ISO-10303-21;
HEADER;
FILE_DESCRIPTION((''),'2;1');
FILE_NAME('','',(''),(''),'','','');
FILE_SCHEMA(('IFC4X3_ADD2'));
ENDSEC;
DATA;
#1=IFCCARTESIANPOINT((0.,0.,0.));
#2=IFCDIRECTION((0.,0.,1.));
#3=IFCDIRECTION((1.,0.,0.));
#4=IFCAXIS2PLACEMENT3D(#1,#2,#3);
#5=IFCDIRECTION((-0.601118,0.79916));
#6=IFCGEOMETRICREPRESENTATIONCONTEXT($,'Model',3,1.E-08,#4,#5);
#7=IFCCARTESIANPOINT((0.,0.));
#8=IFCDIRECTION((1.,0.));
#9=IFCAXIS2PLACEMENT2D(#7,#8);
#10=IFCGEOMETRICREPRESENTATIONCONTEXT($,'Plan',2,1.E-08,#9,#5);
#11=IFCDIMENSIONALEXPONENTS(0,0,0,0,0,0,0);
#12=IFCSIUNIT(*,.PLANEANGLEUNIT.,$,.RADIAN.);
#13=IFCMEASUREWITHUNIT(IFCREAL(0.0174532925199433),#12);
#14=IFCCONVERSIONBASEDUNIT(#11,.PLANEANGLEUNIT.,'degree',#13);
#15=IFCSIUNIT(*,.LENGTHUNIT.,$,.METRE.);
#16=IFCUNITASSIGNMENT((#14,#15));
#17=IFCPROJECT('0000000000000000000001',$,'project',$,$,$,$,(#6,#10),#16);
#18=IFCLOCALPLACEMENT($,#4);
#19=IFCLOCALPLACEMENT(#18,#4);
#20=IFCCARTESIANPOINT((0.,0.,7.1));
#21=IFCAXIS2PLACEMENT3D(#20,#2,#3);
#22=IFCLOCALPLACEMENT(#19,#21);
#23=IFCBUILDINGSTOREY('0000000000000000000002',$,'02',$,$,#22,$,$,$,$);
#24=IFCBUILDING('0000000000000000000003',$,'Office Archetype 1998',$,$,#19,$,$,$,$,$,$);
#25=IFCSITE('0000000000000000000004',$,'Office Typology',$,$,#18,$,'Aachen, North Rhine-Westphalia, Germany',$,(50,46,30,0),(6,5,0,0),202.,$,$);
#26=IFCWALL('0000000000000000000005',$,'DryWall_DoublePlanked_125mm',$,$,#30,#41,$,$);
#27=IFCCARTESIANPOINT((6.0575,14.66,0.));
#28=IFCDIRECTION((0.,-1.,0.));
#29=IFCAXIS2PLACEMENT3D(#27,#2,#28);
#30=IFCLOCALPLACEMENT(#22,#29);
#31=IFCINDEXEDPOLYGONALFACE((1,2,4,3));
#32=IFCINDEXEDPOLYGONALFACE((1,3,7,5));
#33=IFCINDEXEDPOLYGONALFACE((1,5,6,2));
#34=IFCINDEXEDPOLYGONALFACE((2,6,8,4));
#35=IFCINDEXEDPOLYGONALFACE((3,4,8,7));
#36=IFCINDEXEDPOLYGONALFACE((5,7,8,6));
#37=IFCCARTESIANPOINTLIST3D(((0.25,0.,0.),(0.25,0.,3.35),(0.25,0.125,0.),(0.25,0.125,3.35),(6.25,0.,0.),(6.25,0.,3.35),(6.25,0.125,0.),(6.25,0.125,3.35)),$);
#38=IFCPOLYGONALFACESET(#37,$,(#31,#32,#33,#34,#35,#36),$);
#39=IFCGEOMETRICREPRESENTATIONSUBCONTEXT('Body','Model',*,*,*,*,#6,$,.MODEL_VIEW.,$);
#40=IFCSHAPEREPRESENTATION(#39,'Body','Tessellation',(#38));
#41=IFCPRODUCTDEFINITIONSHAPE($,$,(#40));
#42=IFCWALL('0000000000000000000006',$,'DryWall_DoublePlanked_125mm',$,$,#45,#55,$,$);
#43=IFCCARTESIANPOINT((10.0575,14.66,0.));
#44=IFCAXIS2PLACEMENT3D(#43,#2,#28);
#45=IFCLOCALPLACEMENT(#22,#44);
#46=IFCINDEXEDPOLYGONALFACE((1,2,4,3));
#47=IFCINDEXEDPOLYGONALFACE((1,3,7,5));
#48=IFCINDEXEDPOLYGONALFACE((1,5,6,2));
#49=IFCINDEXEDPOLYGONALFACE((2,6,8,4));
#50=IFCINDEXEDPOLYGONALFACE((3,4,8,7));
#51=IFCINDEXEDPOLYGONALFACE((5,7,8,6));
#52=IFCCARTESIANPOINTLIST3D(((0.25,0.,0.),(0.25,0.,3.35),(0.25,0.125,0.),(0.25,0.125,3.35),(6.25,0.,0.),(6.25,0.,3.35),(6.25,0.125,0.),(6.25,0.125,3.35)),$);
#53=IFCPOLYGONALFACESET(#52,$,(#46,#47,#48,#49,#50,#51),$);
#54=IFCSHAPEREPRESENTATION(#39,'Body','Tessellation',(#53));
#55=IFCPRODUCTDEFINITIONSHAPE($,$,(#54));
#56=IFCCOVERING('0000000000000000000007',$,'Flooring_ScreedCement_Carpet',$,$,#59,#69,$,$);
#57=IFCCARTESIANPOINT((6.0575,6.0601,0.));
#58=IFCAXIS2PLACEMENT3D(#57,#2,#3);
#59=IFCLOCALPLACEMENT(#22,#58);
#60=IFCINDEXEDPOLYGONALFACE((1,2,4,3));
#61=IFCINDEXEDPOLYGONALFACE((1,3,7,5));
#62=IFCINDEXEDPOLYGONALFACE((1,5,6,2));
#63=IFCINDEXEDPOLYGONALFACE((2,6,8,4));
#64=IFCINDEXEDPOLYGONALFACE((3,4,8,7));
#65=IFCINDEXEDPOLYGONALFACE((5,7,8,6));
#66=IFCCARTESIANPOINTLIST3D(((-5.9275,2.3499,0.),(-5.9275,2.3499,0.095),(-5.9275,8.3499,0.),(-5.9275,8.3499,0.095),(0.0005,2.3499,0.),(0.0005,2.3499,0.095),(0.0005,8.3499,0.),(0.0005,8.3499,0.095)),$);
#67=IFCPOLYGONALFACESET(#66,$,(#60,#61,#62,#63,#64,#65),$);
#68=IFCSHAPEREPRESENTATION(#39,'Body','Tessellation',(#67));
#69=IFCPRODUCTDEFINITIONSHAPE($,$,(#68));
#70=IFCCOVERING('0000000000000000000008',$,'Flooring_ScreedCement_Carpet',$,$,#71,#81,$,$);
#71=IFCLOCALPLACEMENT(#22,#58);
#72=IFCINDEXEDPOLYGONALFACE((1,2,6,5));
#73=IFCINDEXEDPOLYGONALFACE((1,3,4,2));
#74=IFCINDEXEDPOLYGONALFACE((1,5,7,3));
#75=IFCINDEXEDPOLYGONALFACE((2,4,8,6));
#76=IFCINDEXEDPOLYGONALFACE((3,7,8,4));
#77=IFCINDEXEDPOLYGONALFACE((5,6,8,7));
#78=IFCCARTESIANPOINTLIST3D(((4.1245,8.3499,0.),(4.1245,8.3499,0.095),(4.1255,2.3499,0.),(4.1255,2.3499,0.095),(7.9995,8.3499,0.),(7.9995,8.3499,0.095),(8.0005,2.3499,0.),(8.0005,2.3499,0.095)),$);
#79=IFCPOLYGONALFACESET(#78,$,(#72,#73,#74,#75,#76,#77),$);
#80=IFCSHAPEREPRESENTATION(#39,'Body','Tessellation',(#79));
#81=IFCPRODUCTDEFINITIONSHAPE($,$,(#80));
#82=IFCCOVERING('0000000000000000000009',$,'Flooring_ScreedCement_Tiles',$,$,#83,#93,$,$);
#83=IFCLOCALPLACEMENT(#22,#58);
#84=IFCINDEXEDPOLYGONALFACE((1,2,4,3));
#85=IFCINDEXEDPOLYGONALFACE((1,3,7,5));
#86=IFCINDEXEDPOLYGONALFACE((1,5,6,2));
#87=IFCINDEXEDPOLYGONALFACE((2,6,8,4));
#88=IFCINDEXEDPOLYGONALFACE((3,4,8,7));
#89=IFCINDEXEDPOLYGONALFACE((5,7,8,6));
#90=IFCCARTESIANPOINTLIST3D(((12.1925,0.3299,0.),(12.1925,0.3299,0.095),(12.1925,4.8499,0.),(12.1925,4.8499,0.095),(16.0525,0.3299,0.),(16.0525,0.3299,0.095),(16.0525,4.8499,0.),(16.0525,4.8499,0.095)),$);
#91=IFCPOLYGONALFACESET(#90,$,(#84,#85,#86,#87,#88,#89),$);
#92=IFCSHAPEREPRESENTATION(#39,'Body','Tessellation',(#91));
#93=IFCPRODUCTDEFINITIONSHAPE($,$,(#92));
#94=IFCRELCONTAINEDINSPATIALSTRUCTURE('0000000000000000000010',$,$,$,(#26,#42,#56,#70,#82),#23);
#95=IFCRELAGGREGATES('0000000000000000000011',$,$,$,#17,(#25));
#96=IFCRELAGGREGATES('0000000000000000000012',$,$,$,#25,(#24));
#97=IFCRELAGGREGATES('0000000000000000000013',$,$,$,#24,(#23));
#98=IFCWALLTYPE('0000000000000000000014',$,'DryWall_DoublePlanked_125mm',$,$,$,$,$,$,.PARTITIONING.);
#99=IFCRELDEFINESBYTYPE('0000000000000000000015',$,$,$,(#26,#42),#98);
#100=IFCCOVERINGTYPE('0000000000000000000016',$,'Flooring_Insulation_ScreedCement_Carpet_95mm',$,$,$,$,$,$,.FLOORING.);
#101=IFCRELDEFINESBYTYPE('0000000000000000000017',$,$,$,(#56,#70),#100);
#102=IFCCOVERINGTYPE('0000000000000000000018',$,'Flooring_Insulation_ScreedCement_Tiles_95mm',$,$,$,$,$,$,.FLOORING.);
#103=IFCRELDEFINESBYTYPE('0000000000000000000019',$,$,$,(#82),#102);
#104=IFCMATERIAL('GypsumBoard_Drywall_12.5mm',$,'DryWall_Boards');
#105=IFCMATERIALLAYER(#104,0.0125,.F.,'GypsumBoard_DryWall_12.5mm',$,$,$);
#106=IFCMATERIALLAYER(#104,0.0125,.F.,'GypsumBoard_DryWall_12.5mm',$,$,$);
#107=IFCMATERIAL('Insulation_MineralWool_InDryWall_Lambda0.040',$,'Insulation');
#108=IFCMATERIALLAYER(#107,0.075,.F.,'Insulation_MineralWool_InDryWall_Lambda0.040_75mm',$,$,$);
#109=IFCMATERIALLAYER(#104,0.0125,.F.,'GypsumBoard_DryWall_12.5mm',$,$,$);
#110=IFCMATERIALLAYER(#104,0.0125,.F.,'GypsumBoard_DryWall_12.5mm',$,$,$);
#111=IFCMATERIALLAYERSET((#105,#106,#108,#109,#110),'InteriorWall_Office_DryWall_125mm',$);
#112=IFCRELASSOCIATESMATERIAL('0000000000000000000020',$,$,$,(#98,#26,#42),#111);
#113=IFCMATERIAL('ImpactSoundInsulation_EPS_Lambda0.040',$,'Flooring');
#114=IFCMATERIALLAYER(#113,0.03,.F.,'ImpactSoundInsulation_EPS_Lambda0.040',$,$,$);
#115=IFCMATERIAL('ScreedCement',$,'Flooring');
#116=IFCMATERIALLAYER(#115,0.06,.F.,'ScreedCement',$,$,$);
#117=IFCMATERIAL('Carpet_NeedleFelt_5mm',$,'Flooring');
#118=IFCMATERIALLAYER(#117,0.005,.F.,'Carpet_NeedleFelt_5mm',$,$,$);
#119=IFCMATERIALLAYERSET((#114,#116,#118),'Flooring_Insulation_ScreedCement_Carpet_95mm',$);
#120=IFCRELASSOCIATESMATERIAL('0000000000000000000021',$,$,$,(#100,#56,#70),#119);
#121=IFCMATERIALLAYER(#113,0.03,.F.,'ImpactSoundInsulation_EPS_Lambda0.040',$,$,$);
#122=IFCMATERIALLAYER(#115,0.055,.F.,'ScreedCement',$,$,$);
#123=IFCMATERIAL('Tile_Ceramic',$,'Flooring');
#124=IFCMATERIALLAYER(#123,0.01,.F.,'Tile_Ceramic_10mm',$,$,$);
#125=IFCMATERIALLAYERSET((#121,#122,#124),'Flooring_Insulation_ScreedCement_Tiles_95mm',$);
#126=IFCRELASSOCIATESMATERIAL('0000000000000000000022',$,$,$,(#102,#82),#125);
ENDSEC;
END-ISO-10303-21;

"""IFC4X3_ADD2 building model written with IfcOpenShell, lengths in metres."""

from ifc_helpers import new_model, entity, si_unit, converted_unit, direction, frame, origin_with_axes, origin_2d_with_axis, place, context, subcontext, project, spatial, line, indexed_curve, outline, extrude, material, layer, layer_set, layer_usage, type_object, element, save


model = new_model("IFC4X3_ADD2")

# Units and contexts
model_context = context("Model", 3, precision=1e-08, world=origin_with_axes(), true_north=direction((-0.601118, 0.79916)))
plan_context = context("Plan", 2, precision=1e-08, world=origin_2d_with_axis(), true_north=direction((-0.601118, 0.79916)))
body_context = subcontext(model_context, "Body", "Model", "MODEL_VIEW")
ifc_project = project(units=[converted_unit("PLANEANGLEUNIT", "degree", entity("IfcReal", 0.0174532925199433), si_unit("PLANEANGLEUNIT", "RADIAN"), dimensions=[0, 0, 0, 0, 0, 0, 0]), si_unit("LENGTHUNIT", "METRE")], contexts=[model_context, plan_context])

# Site, building, storey
site_placement = place(None, origin_with_axes())
site = spatial("IfcSite", under=ifc_project, at=site_placement, Name="Office Typology", LongName="Aachen, North Rhine-Westphalia, Germany", RefLatitude=(50, 46, 30, 0), RefLongitude=(6, 5, 0, 0), RefElevation=202.0)
building_placement = place(site_placement, origin_with_axes())
building = spatial("IfcBuilding", under=site, at=building_placement, Name="Office Archetype 1998")
storey_placement = place(building_placement, frame((0.0, 0.0, 7.1), z_axis=(0.0, 0.0, 1.0), x_axis=(1.0, 0.0, 0.0)))
storey = spatial("IfcBuildingStorey", under=building, at=storey_placement, Name="02")

# Walls
ifc_material_1 = material(Name="GypsumBoard_Drywall_12.5mm", Category="DryWall_Boards")
ifc_layer_1 = layer(ifc_material_1, 0.0125, ventilated=False, Name="GypsumBoard_DryWall_12.5mm")
ifc_layer_2 = layer(ifc_material_1, 0.0125, ventilated=False, Name="GypsumBoard_DryWall_12.5mm")
ifc_material_2 = material(Name="Insulation_MineralWool_InDryWall_Lambda0.040", Category="Insulation")
ifc_layer_3 = layer(ifc_material_2, 0.075, ventilated=False, Name="Insulation_MineralWool_InDryWall_Lambda0.040_75mm")
ifc_layer_4 = layer(ifc_material_1, 0.0125, ventilated=False, Name="GypsumBoard_DryWall_12.5mm")
ifc_layer_5 = layer(ifc_material_1, 0.0125, ventilated=False, Name="GypsumBoard_DryWall_12.5mm")
ifc_layer_set_1 = layer_set([ifc_layer_1, ifc_layer_2, ifc_layer_3, ifc_layer_4, ifc_layer_5], Name="InteriorWall_Office_DryWall_125mm")
wall_type_1 = type_object("IfcWallType", Name="DryWall_DoublePlanked_125mm", PredefinedType="PARTITIONING", material=ifc_layer_set_1)
ifc_layer_usage_1 = layer_usage(ifc_layer_set_1, "AXIS2", "POSITIVE", 0.0)
wall_1_placement = place(storey_placement, frame((6.0575, 14.66, 0.0), z_axis=(0.0, 0.0, 1.0), x_axis=(0.0, -1.0, 0.0)))
element("IfcWall", 1, at=wall_1_placement, inside=storey, type_object=wall_type_1, material=ifc_layer_usage_1, Name="DryWall_DoublePlanked_125mm", context=body_context, shape_type="SweptSolid", body=[
    extrude(outline(indexed_curve([(0.25, 0.0), (0.25, 0.125), (6.25, 0.125), (6.25, 0.0)], segments=[line(1, 2, 3, 4, 1)])), origin_with_axes(), (0.0, 0.0, 1.0), 3.35),
])
ifc_layer_usage_2 = layer_usage(ifc_layer_set_1, "AXIS2", "POSITIVE", 0.0)
wall_2_placement = place(storey_placement, frame((10.0575, 14.66, 0.0), z_axis=(0.0, 0.0, 1.0), x_axis=(0.0, -1.0, 0.0)))
element("IfcWall", 2, at=wall_2_placement, inside=storey, type_object=wall_type_1, material=ifc_layer_usage_2, Name="DryWall_DoublePlanked_125mm", context=body_context, shape_type="SweptSolid", body=[
    extrude(outline(indexed_curve([(0.25, 0.0), (0.25, 0.125), (6.25, 0.125), (6.25, 0.0)], segments=[line(1, 2, 3, 4, 1)])), origin_with_axes(), (0.0, 0.0, 1.0), 3.35),
])

# Coverings
ifc_material_3 = material(Name="ImpactSoundInsulation_EPS_Lambda0.040", Category="Flooring")
ifc_layer_6 = layer(ifc_material_3, 0.03, ventilated=False, Name="ImpactSoundInsulation_EPS_Lambda0.040")
ifc_material_4 = material(Name="ScreedCement", Category="Flooring")
ifc_layer_7 = layer(ifc_material_4, 0.06, ventilated=False, Name="ScreedCement")
ifc_material_5 = material(Name="Carpet_NeedleFelt_5mm", Category="Flooring")
ifc_layer_8 = layer(ifc_material_5, 0.005, ventilated=False, Name="Carpet_NeedleFelt_5mm")
ifc_layer_set_2 = layer_set([ifc_layer_6, ifc_layer_7, ifc_layer_8], Name="Flooring_Insulation_ScreedCement_Carpet_95mm")
ifc_layer_usage_3 = layer_usage(ifc_layer_set_2, "AXIS3", "POSITIVE", 0.0)
covering_type_1 = type_object("IfcCoveringType", Name="Flooring_Insulation_ScreedCement_Carpet_95mm", PredefinedType="FLOORING", material=ifc_layer_set_2)
covering_1_placement = place(storey_placement, frame((6.0575, 6.0601, 0.0), z_axis=(0.0, 0.0, 1.0), x_axis=(1.0, 0.0, 0.0)))
element("IfcCovering", 3, at=covering_1_placement, inside=storey, type_object=covering_type_1, material=ifc_layer_usage_3, Name="Flooring_ScreedCement_Carpet", context=body_context, shape_type="SweptSolid", body=[
    extrude(outline(indexed_curve([(-5.9275, 2.3499), (-5.9275, 8.3499), (0.0005, 8.3499), (0.0005, 2.3499)], segments=[line(1, 2, 3, 4, 1)])), origin_with_axes(), (0.0, 0.0, 1.0), 0.095),
])
ifc_layer_usage_4 = layer_usage(ifc_layer_set_2, "AXIS3", "POSITIVE", 0.0)
covering_2_placement = place(storey_placement, frame((6.0575, 6.0601, 0.0), z_axis=(0.0, 0.0, 1.0), x_axis=(1.0, 0.0, 0.0)))
element("IfcCovering", 4, at=covering_2_placement, inside=storey, type_object=covering_type_1, material=ifc_layer_usage_4, Name="Flooring_ScreedCement_Carpet", context=body_context, shape_type="SweptSolid", body=[
    extrude(outline(indexed_curve([(4.1255, 2.3499), (4.1245, 8.3499), (7.9995, 8.3499), (8.0005, 2.3499)], segments=[line(1, 2, 3, 4, 1)])), origin_with_axes(), (0.0, 0.0, 1.0), 0.095),
])
ifc_layer_9 = layer(ifc_material_3, 0.03, ventilated=False, Name="ImpactSoundInsulation_EPS_Lambda0.040")
ifc_layer_10 = layer(ifc_material_4, 0.055, ventilated=False, Name="ScreedCement")
ifc_material_6 = material(Name="Tile_Ceramic", Category="Flooring")
ifc_layer_11 = layer(ifc_material_6, 0.01, ventilated=False, Name="Tile_Ceramic_10mm")
ifc_layer_set_3 = layer_set([ifc_layer_9, ifc_layer_10, ifc_layer_11], Name="Flooring_Insulation_ScreedCement_Tiles_95mm")
ifc_layer_usage_5 = layer_usage(ifc_layer_set_3, "AXIS3", "POSITIVE", 0.0)
covering_type_2 = type_object("IfcCoveringType", Name="Flooring_Insulation_ScreedCement_Tiles_95mm", PredefinedType="FLOORING", material=ifc_layer_set_3)
covering_3_placement = place(storey_placement, frame((6.0575, 6.0601, 0.0), z_axis=(0.0, 0.0, 1.0), x_axis=(1.0, 0.0, 0.0)))
element("IfcCovering", 5, at=covering_3_placement, inside=storey, type_object=covering_type_2, material=ifc_layer_usage_5, Name="Flooring_ScreedCement_Tiles", context=body_context, shape_type="SweptSolid", body=[
    extrude(outline(indexed_curve([(12.1925, 0.3299), (12.1925, 4.8499), (16.0525, 4.8499), (16.0525, 0.3299)], segments=[line(1, 2, 3, 4, 1)])), origin_with_axes(), (0.0, 0.0, 1.0), 0.095),
])

save(model, "model.ifc")
